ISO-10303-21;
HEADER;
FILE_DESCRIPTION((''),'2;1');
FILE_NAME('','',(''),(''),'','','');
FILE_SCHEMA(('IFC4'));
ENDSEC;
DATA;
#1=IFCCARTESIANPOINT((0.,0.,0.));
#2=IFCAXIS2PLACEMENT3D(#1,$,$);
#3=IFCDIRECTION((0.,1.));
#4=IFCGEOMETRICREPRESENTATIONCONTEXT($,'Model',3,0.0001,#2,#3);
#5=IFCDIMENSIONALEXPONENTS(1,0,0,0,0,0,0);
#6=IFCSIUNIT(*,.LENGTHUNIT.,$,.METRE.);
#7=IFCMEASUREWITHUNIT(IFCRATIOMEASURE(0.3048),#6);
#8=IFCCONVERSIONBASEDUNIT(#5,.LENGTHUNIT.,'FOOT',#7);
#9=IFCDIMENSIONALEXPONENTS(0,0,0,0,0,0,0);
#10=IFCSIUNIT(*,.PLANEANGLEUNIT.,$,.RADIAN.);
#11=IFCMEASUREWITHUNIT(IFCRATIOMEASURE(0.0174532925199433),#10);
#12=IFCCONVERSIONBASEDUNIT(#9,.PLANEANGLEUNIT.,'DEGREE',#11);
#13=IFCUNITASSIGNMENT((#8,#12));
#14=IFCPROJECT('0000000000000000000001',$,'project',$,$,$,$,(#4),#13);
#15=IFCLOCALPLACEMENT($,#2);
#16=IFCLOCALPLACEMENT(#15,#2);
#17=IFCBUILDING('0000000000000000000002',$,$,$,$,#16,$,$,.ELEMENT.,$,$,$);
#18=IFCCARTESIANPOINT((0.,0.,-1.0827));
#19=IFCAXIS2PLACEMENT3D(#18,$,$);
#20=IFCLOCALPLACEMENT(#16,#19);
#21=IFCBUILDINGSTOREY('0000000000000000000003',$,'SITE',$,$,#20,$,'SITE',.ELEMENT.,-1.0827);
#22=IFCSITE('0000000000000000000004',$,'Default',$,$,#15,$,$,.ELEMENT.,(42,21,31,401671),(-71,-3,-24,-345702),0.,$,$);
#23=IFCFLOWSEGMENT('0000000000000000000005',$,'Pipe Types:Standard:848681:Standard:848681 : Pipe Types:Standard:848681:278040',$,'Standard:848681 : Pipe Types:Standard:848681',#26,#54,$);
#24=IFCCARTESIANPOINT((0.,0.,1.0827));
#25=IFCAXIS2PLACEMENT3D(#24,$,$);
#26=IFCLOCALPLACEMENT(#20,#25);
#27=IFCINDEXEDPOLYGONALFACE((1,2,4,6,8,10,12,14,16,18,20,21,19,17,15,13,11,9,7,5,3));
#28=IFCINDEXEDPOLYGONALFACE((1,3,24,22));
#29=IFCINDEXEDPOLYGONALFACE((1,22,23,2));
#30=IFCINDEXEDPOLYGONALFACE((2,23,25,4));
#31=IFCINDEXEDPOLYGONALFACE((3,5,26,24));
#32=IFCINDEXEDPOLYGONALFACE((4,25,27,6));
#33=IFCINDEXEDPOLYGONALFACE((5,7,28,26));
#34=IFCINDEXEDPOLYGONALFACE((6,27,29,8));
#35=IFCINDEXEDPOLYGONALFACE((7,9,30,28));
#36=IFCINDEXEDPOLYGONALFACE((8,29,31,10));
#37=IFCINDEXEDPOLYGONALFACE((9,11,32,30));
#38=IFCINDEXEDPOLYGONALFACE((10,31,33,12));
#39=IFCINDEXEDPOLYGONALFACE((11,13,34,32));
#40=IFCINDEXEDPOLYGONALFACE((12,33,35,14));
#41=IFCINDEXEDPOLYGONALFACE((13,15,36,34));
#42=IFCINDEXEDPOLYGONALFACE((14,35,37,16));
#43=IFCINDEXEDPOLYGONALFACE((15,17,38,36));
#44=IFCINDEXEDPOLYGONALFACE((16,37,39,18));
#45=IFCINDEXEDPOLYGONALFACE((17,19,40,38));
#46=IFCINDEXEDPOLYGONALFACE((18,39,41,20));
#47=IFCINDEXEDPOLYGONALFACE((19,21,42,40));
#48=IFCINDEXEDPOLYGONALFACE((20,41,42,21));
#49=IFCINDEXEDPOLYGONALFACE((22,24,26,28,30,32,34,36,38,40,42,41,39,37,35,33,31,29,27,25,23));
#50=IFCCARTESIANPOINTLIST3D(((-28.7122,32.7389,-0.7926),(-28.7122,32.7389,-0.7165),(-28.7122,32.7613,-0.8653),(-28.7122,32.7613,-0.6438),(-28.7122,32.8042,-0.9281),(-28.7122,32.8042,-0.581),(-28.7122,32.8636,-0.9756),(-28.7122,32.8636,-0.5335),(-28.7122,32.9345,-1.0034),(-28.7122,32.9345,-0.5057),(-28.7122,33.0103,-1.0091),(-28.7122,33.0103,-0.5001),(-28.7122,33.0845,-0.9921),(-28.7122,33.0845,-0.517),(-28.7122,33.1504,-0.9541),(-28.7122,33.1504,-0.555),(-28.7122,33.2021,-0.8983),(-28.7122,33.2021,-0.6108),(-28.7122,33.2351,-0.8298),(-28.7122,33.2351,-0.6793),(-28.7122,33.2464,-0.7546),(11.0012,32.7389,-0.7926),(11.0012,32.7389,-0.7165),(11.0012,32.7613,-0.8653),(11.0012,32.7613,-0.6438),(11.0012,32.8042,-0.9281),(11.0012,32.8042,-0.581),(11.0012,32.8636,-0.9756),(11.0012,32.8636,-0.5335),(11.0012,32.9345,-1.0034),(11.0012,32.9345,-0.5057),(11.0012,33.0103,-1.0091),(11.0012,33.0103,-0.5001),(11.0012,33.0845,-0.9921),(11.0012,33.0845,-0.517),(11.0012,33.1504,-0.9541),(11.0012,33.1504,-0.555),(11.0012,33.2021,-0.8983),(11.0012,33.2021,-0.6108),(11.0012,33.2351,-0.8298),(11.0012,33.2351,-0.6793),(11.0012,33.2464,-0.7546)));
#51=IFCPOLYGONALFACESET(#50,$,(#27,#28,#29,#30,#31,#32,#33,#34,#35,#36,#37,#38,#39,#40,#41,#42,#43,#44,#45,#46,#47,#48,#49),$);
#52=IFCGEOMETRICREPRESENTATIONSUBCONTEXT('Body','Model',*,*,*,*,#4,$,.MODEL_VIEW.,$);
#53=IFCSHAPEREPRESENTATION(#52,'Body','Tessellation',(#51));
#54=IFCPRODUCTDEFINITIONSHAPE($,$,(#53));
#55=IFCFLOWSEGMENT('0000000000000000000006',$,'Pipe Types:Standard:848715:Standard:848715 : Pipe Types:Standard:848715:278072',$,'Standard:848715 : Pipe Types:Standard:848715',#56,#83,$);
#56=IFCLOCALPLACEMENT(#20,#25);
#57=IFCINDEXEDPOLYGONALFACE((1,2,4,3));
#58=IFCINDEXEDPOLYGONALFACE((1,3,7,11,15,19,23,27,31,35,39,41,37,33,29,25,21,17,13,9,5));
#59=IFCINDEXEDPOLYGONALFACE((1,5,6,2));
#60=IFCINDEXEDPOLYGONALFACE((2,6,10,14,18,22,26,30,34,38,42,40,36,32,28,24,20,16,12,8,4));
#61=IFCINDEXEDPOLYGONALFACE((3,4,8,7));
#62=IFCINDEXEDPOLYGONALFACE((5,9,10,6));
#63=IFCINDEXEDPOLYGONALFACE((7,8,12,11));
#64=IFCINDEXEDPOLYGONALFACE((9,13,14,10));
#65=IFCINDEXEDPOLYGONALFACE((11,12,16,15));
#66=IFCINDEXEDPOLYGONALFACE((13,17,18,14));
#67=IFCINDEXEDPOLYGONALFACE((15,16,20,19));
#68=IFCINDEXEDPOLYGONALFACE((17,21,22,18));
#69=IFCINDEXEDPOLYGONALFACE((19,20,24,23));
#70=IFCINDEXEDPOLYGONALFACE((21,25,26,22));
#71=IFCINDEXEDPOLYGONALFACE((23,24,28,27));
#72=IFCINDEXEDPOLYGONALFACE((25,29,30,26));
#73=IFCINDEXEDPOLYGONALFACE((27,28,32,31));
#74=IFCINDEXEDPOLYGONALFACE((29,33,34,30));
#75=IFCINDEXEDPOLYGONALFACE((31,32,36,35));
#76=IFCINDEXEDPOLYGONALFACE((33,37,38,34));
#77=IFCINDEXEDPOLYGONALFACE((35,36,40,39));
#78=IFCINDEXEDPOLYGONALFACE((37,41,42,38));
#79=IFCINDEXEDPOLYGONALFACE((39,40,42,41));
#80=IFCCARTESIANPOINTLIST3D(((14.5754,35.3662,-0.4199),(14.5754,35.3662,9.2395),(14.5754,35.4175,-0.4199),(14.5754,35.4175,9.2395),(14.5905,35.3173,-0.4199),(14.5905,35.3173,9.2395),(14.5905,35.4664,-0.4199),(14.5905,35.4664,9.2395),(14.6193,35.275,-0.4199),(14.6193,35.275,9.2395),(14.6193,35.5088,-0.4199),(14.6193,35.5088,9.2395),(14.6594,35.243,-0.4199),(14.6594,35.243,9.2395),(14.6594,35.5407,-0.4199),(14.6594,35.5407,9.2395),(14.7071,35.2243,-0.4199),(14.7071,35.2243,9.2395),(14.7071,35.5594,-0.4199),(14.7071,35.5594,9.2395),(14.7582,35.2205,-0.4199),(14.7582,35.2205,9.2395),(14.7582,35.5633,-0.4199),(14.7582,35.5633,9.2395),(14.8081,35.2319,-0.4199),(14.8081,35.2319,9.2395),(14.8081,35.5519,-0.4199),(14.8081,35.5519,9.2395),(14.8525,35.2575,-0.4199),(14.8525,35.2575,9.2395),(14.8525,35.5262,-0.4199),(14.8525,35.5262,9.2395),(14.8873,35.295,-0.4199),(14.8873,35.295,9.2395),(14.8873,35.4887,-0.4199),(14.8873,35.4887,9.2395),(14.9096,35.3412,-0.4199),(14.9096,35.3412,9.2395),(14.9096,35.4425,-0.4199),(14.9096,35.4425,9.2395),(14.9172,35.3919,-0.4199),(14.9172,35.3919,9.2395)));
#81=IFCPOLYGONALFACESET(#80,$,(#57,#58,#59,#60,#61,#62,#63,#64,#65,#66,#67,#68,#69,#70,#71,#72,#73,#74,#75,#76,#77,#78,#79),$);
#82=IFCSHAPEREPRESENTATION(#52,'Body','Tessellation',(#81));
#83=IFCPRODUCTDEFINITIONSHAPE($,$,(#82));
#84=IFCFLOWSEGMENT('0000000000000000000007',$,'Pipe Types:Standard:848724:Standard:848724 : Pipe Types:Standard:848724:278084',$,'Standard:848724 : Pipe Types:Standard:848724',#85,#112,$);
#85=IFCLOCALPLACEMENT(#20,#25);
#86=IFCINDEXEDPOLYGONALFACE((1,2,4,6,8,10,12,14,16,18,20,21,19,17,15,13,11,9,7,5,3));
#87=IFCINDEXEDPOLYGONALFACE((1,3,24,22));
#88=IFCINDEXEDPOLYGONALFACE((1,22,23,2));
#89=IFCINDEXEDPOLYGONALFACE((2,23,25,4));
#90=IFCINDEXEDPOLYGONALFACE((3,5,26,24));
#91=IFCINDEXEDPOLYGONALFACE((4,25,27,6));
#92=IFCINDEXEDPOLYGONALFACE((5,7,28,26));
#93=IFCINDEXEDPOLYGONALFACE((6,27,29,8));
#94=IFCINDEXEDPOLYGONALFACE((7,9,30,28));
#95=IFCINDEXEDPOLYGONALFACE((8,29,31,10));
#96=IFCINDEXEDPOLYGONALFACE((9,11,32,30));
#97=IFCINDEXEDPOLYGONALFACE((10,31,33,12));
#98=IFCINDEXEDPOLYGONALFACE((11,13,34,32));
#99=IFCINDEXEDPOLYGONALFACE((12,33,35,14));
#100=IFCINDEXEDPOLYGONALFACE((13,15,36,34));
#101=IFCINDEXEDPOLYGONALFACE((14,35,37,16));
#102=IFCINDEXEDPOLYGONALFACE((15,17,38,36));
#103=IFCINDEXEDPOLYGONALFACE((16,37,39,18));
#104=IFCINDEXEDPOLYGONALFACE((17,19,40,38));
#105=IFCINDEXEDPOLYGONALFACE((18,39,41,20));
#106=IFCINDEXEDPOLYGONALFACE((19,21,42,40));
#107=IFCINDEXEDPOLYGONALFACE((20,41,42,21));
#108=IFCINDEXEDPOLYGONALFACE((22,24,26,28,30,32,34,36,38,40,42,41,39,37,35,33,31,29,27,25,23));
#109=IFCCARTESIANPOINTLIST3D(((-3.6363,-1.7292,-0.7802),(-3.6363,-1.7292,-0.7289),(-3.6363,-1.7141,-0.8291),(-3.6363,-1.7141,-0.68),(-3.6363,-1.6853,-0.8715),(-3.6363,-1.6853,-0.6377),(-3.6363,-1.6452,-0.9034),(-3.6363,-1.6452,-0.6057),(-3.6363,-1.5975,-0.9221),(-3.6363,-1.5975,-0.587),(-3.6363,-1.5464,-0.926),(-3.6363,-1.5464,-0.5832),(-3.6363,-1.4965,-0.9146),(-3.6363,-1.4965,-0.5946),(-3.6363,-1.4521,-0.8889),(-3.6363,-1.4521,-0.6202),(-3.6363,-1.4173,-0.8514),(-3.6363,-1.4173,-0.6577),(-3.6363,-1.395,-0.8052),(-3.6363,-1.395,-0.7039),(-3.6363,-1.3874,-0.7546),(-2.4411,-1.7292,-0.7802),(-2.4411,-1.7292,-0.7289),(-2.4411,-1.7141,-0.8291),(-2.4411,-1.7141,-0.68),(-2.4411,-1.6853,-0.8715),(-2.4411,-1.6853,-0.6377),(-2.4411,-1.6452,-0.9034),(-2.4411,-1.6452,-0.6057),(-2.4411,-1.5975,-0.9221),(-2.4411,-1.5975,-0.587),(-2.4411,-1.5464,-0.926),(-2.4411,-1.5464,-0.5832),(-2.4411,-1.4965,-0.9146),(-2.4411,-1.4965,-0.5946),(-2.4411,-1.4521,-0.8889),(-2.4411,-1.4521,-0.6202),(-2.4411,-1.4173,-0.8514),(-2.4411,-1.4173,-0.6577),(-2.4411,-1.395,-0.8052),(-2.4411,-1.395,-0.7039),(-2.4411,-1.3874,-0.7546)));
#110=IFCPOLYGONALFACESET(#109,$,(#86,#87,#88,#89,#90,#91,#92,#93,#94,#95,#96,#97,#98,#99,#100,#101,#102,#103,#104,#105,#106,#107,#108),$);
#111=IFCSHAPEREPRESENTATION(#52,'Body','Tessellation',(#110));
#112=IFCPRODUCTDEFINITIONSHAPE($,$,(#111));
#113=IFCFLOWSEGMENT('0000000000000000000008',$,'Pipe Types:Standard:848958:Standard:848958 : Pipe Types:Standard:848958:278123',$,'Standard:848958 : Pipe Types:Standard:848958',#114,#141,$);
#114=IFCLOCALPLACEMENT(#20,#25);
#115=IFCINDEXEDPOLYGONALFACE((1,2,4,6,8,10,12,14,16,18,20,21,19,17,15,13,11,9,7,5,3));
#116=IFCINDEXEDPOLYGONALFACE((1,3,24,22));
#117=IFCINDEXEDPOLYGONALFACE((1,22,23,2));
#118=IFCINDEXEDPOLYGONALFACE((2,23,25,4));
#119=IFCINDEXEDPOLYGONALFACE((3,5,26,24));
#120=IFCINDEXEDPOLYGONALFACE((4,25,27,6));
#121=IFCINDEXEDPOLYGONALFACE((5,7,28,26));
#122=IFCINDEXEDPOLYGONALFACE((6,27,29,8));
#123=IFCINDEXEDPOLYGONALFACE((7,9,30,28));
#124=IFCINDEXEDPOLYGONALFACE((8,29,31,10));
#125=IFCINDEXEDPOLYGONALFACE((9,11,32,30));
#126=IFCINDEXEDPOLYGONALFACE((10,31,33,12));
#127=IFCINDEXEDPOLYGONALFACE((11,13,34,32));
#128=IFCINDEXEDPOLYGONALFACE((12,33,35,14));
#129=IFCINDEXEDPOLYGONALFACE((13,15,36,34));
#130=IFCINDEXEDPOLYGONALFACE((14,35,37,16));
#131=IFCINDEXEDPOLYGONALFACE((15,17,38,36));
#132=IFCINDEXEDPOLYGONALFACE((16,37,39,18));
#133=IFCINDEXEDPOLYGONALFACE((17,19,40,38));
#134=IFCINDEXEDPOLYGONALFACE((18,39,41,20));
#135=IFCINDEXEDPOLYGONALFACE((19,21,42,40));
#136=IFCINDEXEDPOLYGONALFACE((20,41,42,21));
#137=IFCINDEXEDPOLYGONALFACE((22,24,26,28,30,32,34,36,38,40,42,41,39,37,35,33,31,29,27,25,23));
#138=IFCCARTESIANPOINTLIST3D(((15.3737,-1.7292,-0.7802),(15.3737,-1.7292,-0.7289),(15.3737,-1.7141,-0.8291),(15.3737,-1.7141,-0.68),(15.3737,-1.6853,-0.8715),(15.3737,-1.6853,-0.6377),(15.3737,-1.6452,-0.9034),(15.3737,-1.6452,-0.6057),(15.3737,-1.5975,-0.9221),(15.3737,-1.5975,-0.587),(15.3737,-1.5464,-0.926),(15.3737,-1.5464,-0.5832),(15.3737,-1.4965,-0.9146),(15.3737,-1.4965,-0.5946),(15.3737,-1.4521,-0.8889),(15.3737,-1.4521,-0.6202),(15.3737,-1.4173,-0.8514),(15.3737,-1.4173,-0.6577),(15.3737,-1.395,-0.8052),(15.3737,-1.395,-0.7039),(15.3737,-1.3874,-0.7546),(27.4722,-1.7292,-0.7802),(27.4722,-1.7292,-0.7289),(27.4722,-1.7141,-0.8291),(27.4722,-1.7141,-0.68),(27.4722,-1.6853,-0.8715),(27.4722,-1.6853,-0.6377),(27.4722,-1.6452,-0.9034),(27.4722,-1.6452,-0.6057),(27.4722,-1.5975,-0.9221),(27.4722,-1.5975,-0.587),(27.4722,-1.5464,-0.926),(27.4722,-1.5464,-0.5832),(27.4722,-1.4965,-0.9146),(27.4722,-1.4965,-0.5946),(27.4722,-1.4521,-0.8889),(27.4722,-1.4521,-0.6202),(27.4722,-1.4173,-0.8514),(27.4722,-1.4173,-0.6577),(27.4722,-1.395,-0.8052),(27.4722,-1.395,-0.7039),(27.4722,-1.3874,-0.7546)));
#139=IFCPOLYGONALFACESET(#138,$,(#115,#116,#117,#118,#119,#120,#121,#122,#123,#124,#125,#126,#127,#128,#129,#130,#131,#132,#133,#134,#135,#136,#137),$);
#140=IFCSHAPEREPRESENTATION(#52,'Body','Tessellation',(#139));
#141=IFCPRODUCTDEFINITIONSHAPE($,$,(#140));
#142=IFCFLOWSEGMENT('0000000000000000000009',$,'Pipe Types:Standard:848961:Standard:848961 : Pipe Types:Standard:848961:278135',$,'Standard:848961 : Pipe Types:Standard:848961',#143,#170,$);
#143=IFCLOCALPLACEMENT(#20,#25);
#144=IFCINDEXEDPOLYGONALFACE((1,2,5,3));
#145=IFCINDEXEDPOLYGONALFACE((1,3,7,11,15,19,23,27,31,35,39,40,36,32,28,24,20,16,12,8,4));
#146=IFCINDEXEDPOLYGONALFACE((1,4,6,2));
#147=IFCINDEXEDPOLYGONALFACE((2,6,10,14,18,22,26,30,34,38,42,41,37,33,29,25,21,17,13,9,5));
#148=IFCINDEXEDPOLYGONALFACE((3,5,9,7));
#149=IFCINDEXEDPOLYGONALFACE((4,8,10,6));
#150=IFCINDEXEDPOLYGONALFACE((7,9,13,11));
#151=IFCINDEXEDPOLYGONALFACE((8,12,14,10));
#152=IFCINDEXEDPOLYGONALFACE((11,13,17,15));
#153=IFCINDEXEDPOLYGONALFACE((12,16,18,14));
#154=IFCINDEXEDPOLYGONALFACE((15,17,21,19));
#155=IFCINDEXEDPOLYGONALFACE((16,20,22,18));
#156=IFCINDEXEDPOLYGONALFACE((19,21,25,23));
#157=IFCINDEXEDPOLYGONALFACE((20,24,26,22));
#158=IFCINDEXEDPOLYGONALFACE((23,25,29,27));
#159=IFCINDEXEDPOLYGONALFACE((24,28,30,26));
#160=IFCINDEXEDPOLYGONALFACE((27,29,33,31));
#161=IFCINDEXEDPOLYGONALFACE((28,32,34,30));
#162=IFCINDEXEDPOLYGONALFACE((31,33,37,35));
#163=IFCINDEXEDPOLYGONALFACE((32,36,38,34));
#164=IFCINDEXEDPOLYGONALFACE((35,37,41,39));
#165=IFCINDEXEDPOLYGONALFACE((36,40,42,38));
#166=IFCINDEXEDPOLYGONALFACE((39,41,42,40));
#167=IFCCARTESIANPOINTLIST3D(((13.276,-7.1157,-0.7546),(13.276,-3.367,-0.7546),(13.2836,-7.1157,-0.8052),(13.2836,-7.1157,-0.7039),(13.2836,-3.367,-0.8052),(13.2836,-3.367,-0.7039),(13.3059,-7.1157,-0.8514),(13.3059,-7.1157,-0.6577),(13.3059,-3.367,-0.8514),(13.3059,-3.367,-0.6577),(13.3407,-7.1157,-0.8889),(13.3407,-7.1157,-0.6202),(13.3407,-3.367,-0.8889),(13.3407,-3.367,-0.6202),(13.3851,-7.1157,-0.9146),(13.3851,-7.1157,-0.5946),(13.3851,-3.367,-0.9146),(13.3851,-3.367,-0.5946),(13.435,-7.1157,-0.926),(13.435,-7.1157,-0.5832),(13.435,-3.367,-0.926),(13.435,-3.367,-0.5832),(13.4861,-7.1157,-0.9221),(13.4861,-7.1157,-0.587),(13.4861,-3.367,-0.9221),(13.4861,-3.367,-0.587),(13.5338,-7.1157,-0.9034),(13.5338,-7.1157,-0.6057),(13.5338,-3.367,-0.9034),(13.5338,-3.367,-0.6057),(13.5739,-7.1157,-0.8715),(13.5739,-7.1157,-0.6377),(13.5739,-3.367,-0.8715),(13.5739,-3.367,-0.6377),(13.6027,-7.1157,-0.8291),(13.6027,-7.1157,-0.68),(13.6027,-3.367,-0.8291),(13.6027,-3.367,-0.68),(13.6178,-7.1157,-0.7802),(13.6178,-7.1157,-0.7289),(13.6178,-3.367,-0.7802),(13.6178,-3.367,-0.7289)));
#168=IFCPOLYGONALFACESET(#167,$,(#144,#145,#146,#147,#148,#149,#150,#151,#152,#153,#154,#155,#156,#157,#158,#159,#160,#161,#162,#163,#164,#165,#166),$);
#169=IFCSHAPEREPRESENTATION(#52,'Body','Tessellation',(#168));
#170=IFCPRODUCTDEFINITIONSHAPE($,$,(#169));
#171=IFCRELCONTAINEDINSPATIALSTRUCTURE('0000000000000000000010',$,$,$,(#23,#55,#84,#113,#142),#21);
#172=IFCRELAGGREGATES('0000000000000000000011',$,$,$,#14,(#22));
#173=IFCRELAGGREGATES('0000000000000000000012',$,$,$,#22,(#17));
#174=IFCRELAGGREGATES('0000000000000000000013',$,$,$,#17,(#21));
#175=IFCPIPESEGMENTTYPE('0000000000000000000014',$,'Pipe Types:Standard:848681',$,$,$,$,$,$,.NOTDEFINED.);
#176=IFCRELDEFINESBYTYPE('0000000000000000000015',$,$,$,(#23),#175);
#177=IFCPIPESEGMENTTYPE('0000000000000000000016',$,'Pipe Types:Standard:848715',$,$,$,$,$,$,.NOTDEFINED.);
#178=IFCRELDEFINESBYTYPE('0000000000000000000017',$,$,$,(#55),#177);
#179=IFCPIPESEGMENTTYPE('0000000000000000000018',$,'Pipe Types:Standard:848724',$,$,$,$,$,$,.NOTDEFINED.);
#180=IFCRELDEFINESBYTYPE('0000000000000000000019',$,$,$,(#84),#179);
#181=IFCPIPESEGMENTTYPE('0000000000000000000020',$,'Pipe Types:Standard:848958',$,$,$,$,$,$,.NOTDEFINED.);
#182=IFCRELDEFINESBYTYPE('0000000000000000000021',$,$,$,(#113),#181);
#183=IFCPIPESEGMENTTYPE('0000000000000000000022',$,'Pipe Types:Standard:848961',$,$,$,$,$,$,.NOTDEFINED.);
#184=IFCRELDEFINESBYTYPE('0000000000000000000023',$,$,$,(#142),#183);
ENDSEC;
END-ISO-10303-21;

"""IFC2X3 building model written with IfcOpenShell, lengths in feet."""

from ifc_helpers import new_model, entity, si_unit, converted_unit, direction, frame, frame_2d, origin, origin_2d_with_axis, place, context, subcontext, project, spatial, circle, extrude, source, transform, mapped, type_object, type_shapes, element, save


model = new_model("IFC2X3")

# Units and contexts
model_context = context("Model", 3, precision=0.0001, world=origin(), true_north=direction((0.0, 1.0)))
body_context = subcontext(model_context, "Body", "Model", "MODEL_VIEW")
ifc_project = project(units=[converted_unit("LENGTHUNIT", "FOOT", entity("IfcRatioMeasure", 0.3048), si_unit("LENGTHUNIT", "METRE"), dimensions=[1, 0, 0, 0, 0, 0, 0]), converted_unit("PLANEANGLEUNIT", "DEGREE", entity("IfcRatioMeasure", 0.0174532925199433), si_unit("PLANEANGLEUNIT", "RADIAN"), dimensions=[0, 0, 0, 0, 0, 0, 0])], contexts=[model_context])

# Site, building, storey
site_placement = place(None, origin())
site = spatial("IfcSite", under=ifc_project, at=site_placement, Name="Default", CompositionType="ELEMENT", RefLatitude=(42, 21, 31, 401671), RefLongitude=(-71, -3, -24, -345702), RefElevation=0.0)
building_placement = place(site_placement, origin())
building = spatial("IfcBuilding", under=site, at=building_placement, CompositionType="ELEMENT")
storey_placement = place(building_placement, frame((0.0, 0.0, -1.0827)))
storey = spatial("IfcBuildingStorey", under=building, at=storey_placement, Name="SITE", LongName="SITE", CompositionType="ELEMENT", Elevation=-1.0827)

# Flow segments
pipe_segment_type_1 = type_object("IfcPipeSegmentType", Name="Pipe Types:Standard:848681", PredefinedType="NOTDEFINED")
shared_shape_1 = source(origin(), body_context, "Body", "SweptSolid", [
    extrude(circle(Radius=0.2552, at=frame_2d((0.0, 0.0), x_axis=(1.0, 0.0))), frame((-28.7122, 32.9912, -0.7546), z_axis=(1.0, 0.0, 0.0), x_axis=(0.0, 1.0, 0.0)), (0.0, 0.0, 1.0), 39.7134),
])
type_shapes(pipe_segment_type_1, [shared_shape_1])
flow_segment_1_placement = place(storey_placement, frame((0.0, 0.0, 1.0827)))
element("IfcFlowSegment", 1, at=flow_segment_1_placement, inside=storey, type_object=pipe_segment_type_1, Name="Pipe Types:Standard:848681:Standard:848681 : Pipe Types:Standard:848681:278040", ObjectType="Standard:848681 : Pipe Types:Standard:848681", context=body_context, shape_type="MappedRepresentation", body=[
    mapped(shared_shape_1, transform((0.0, 0.0, 0.0), scale=1.0)),
])
pipe_segment_type_2 = type_object("IfcPipeSegmentType", Name="Pipe Types:Standard:848715", PredefinedType="NOTDEFINED")
shared_shape_2 = source(origin(), body_context, "Body", "SweptSolid", [
    extrude(circle(Radius=0.1719, at=origin_2d_with_axis()), frame((14.7453, 35.3919, -0.4199)), (0.0, 0.0, 1.0), 9.6594),
])
type_shapes(pipe_segment_type_2, [shared_shape_2])
flow_segment_2_placement = place(storey_placement, frame((0.0, 0.0, 1.0827)))
element("IfcFlowSegment", 2, at=flow_segment_2_placement, inside=storey, type_object=pipe_segment_type_2, Name="Pipe Types:Standard:848715:Standard:848715 : Pipe Types:Standard:848715:278072", ObjectType="Standard:848715 : Pipe Types:Standard:848715", context=body_context, shape_type="MappedRepresentation", body=[
    mapped(shared_shape_2, transform((0.0, 0.0, 0.0), scale=1.0)),
])
pipe_segment_type_3 = type_object("IfcPipeSegmentType", Name="Pipe Types:Standard:848724", PredefinedType="NOTDEFINED")
shared_shape_3 = source(origin(), body_context, "Body", "SweptSolid", [
    extrude(circle(Radius=0.1719, at=frame_2d((0.0, 0.0), x_axis=(1.0, 0.0))), frame((-3.6363, -1.5593, -0.7546), z_axis=(1.0, 0.0, 0.0), x_axis=(0.0, 1.0, 0.0)), (0.0, 0.0, 1.0), 1.1952),
])
type_shapes(pipe_segment_type_3, [shared_shape_3])
flow_segment_3_placement = place(storey_placement, frame((0.0, 0.0, 1.0827)))
element("IfcFlowSegment", 3, at=flow_segment_3_placement, inside=storey, type_object=pipe_segment_type_3, Name="Pipe Types:Standard:848724:Standard:848724 : Pipe Types:Standard:848724:278084", ObjectType="Standard:848724 : Pipe Types:Standard:848724", context=body_context, shape_type="MappedRepresentation", body=[
    mapped(shared_shape_3, transform((0.0, 0.0, 0.0), scale=1.0)),
])
pipe_segment_type_4 = type_object("IfcPipeSegmentType", Name="Pipe Types:Standard:848958", PredefinedType="NOTDEFINED")
shared_shape_4 = source(origin(), body_context, "Body", "SweptSolid", [
    extrude(circle(Radius=0.1719, at=frame_2d((0.0, 0.0), x_axis=(1.0, 0.0))), frame((15.3737, -1.5593, -0.7546), z_axis=(1.0, 0.0, 0.0), x_axis=(0.0, 1.0, 0.0)), (0.0, 0.0, 1.0), 12.0986),
])
type_shapes(pipe_segment_type_4, [shared_shape_4])
flow_segment_4_placement = place(storey_placement, frame((0.0, 0.0, 1.0827)))
element("IfcFlowSegment", 4, at=flow_segment_4_placement, inside=storey, type_object=pipe_segment_type_4, Name="Pipe Types:Standard:848958:Standard:848958 : Pipe Types:Standard:848958:278123", ObjectType="Standard:848958 : Pipe Types:Standard:848958", context=body_context, shape_type="MappedRepresentation", body=[
    mapped(shared_shape_4, transform((0.0, 0.0, 0.0), scale=1.0)),
])
pipe_segment_type_5 = type_object("IfcPipeSegmentType", Name="Pipe Types:Standard:848961", PredefinedType="NOTDEFINED")
shared_shape_5 = source(origin(), body_context, "Body", "SweptSolid", [
    extrude(circle(Radius=0.1719, at=frame_2d((0.0, 0.0), x_axis=(1.0, 0.0))), frame((13.4479, -7.1157, -0.7546), z_axis=(0.0, 1.0, 0.0), x_axis=(-1.0, 0.0, 0.0)), (0.0, 0.0, 1.0), 3.7487),
])
type_shapes(pipe_segment_type_5, [shared_shape_5])
flow_segment_5_placement = place(storey_placement, frame((0.0, 0.0, 1.0827)))
element("IfcFlowSegment", 5, at=flow_segment_5_placement, inside=storey, type_object=pipe_segment_type_5, Name="Pipe Types:Standard:848961:Standard:848961 : Pipe Types:Standard:848961:278135", ObjectType="Standard:848961 : Pipe Types:Standard:848961", context=body_context, shape_type="MappedRepresentation", body=[
    mapped(shared_shape_5, transform((0.0, 0.0, 0.0), scale=1.0)),
])

save(model, "model.ifc")
